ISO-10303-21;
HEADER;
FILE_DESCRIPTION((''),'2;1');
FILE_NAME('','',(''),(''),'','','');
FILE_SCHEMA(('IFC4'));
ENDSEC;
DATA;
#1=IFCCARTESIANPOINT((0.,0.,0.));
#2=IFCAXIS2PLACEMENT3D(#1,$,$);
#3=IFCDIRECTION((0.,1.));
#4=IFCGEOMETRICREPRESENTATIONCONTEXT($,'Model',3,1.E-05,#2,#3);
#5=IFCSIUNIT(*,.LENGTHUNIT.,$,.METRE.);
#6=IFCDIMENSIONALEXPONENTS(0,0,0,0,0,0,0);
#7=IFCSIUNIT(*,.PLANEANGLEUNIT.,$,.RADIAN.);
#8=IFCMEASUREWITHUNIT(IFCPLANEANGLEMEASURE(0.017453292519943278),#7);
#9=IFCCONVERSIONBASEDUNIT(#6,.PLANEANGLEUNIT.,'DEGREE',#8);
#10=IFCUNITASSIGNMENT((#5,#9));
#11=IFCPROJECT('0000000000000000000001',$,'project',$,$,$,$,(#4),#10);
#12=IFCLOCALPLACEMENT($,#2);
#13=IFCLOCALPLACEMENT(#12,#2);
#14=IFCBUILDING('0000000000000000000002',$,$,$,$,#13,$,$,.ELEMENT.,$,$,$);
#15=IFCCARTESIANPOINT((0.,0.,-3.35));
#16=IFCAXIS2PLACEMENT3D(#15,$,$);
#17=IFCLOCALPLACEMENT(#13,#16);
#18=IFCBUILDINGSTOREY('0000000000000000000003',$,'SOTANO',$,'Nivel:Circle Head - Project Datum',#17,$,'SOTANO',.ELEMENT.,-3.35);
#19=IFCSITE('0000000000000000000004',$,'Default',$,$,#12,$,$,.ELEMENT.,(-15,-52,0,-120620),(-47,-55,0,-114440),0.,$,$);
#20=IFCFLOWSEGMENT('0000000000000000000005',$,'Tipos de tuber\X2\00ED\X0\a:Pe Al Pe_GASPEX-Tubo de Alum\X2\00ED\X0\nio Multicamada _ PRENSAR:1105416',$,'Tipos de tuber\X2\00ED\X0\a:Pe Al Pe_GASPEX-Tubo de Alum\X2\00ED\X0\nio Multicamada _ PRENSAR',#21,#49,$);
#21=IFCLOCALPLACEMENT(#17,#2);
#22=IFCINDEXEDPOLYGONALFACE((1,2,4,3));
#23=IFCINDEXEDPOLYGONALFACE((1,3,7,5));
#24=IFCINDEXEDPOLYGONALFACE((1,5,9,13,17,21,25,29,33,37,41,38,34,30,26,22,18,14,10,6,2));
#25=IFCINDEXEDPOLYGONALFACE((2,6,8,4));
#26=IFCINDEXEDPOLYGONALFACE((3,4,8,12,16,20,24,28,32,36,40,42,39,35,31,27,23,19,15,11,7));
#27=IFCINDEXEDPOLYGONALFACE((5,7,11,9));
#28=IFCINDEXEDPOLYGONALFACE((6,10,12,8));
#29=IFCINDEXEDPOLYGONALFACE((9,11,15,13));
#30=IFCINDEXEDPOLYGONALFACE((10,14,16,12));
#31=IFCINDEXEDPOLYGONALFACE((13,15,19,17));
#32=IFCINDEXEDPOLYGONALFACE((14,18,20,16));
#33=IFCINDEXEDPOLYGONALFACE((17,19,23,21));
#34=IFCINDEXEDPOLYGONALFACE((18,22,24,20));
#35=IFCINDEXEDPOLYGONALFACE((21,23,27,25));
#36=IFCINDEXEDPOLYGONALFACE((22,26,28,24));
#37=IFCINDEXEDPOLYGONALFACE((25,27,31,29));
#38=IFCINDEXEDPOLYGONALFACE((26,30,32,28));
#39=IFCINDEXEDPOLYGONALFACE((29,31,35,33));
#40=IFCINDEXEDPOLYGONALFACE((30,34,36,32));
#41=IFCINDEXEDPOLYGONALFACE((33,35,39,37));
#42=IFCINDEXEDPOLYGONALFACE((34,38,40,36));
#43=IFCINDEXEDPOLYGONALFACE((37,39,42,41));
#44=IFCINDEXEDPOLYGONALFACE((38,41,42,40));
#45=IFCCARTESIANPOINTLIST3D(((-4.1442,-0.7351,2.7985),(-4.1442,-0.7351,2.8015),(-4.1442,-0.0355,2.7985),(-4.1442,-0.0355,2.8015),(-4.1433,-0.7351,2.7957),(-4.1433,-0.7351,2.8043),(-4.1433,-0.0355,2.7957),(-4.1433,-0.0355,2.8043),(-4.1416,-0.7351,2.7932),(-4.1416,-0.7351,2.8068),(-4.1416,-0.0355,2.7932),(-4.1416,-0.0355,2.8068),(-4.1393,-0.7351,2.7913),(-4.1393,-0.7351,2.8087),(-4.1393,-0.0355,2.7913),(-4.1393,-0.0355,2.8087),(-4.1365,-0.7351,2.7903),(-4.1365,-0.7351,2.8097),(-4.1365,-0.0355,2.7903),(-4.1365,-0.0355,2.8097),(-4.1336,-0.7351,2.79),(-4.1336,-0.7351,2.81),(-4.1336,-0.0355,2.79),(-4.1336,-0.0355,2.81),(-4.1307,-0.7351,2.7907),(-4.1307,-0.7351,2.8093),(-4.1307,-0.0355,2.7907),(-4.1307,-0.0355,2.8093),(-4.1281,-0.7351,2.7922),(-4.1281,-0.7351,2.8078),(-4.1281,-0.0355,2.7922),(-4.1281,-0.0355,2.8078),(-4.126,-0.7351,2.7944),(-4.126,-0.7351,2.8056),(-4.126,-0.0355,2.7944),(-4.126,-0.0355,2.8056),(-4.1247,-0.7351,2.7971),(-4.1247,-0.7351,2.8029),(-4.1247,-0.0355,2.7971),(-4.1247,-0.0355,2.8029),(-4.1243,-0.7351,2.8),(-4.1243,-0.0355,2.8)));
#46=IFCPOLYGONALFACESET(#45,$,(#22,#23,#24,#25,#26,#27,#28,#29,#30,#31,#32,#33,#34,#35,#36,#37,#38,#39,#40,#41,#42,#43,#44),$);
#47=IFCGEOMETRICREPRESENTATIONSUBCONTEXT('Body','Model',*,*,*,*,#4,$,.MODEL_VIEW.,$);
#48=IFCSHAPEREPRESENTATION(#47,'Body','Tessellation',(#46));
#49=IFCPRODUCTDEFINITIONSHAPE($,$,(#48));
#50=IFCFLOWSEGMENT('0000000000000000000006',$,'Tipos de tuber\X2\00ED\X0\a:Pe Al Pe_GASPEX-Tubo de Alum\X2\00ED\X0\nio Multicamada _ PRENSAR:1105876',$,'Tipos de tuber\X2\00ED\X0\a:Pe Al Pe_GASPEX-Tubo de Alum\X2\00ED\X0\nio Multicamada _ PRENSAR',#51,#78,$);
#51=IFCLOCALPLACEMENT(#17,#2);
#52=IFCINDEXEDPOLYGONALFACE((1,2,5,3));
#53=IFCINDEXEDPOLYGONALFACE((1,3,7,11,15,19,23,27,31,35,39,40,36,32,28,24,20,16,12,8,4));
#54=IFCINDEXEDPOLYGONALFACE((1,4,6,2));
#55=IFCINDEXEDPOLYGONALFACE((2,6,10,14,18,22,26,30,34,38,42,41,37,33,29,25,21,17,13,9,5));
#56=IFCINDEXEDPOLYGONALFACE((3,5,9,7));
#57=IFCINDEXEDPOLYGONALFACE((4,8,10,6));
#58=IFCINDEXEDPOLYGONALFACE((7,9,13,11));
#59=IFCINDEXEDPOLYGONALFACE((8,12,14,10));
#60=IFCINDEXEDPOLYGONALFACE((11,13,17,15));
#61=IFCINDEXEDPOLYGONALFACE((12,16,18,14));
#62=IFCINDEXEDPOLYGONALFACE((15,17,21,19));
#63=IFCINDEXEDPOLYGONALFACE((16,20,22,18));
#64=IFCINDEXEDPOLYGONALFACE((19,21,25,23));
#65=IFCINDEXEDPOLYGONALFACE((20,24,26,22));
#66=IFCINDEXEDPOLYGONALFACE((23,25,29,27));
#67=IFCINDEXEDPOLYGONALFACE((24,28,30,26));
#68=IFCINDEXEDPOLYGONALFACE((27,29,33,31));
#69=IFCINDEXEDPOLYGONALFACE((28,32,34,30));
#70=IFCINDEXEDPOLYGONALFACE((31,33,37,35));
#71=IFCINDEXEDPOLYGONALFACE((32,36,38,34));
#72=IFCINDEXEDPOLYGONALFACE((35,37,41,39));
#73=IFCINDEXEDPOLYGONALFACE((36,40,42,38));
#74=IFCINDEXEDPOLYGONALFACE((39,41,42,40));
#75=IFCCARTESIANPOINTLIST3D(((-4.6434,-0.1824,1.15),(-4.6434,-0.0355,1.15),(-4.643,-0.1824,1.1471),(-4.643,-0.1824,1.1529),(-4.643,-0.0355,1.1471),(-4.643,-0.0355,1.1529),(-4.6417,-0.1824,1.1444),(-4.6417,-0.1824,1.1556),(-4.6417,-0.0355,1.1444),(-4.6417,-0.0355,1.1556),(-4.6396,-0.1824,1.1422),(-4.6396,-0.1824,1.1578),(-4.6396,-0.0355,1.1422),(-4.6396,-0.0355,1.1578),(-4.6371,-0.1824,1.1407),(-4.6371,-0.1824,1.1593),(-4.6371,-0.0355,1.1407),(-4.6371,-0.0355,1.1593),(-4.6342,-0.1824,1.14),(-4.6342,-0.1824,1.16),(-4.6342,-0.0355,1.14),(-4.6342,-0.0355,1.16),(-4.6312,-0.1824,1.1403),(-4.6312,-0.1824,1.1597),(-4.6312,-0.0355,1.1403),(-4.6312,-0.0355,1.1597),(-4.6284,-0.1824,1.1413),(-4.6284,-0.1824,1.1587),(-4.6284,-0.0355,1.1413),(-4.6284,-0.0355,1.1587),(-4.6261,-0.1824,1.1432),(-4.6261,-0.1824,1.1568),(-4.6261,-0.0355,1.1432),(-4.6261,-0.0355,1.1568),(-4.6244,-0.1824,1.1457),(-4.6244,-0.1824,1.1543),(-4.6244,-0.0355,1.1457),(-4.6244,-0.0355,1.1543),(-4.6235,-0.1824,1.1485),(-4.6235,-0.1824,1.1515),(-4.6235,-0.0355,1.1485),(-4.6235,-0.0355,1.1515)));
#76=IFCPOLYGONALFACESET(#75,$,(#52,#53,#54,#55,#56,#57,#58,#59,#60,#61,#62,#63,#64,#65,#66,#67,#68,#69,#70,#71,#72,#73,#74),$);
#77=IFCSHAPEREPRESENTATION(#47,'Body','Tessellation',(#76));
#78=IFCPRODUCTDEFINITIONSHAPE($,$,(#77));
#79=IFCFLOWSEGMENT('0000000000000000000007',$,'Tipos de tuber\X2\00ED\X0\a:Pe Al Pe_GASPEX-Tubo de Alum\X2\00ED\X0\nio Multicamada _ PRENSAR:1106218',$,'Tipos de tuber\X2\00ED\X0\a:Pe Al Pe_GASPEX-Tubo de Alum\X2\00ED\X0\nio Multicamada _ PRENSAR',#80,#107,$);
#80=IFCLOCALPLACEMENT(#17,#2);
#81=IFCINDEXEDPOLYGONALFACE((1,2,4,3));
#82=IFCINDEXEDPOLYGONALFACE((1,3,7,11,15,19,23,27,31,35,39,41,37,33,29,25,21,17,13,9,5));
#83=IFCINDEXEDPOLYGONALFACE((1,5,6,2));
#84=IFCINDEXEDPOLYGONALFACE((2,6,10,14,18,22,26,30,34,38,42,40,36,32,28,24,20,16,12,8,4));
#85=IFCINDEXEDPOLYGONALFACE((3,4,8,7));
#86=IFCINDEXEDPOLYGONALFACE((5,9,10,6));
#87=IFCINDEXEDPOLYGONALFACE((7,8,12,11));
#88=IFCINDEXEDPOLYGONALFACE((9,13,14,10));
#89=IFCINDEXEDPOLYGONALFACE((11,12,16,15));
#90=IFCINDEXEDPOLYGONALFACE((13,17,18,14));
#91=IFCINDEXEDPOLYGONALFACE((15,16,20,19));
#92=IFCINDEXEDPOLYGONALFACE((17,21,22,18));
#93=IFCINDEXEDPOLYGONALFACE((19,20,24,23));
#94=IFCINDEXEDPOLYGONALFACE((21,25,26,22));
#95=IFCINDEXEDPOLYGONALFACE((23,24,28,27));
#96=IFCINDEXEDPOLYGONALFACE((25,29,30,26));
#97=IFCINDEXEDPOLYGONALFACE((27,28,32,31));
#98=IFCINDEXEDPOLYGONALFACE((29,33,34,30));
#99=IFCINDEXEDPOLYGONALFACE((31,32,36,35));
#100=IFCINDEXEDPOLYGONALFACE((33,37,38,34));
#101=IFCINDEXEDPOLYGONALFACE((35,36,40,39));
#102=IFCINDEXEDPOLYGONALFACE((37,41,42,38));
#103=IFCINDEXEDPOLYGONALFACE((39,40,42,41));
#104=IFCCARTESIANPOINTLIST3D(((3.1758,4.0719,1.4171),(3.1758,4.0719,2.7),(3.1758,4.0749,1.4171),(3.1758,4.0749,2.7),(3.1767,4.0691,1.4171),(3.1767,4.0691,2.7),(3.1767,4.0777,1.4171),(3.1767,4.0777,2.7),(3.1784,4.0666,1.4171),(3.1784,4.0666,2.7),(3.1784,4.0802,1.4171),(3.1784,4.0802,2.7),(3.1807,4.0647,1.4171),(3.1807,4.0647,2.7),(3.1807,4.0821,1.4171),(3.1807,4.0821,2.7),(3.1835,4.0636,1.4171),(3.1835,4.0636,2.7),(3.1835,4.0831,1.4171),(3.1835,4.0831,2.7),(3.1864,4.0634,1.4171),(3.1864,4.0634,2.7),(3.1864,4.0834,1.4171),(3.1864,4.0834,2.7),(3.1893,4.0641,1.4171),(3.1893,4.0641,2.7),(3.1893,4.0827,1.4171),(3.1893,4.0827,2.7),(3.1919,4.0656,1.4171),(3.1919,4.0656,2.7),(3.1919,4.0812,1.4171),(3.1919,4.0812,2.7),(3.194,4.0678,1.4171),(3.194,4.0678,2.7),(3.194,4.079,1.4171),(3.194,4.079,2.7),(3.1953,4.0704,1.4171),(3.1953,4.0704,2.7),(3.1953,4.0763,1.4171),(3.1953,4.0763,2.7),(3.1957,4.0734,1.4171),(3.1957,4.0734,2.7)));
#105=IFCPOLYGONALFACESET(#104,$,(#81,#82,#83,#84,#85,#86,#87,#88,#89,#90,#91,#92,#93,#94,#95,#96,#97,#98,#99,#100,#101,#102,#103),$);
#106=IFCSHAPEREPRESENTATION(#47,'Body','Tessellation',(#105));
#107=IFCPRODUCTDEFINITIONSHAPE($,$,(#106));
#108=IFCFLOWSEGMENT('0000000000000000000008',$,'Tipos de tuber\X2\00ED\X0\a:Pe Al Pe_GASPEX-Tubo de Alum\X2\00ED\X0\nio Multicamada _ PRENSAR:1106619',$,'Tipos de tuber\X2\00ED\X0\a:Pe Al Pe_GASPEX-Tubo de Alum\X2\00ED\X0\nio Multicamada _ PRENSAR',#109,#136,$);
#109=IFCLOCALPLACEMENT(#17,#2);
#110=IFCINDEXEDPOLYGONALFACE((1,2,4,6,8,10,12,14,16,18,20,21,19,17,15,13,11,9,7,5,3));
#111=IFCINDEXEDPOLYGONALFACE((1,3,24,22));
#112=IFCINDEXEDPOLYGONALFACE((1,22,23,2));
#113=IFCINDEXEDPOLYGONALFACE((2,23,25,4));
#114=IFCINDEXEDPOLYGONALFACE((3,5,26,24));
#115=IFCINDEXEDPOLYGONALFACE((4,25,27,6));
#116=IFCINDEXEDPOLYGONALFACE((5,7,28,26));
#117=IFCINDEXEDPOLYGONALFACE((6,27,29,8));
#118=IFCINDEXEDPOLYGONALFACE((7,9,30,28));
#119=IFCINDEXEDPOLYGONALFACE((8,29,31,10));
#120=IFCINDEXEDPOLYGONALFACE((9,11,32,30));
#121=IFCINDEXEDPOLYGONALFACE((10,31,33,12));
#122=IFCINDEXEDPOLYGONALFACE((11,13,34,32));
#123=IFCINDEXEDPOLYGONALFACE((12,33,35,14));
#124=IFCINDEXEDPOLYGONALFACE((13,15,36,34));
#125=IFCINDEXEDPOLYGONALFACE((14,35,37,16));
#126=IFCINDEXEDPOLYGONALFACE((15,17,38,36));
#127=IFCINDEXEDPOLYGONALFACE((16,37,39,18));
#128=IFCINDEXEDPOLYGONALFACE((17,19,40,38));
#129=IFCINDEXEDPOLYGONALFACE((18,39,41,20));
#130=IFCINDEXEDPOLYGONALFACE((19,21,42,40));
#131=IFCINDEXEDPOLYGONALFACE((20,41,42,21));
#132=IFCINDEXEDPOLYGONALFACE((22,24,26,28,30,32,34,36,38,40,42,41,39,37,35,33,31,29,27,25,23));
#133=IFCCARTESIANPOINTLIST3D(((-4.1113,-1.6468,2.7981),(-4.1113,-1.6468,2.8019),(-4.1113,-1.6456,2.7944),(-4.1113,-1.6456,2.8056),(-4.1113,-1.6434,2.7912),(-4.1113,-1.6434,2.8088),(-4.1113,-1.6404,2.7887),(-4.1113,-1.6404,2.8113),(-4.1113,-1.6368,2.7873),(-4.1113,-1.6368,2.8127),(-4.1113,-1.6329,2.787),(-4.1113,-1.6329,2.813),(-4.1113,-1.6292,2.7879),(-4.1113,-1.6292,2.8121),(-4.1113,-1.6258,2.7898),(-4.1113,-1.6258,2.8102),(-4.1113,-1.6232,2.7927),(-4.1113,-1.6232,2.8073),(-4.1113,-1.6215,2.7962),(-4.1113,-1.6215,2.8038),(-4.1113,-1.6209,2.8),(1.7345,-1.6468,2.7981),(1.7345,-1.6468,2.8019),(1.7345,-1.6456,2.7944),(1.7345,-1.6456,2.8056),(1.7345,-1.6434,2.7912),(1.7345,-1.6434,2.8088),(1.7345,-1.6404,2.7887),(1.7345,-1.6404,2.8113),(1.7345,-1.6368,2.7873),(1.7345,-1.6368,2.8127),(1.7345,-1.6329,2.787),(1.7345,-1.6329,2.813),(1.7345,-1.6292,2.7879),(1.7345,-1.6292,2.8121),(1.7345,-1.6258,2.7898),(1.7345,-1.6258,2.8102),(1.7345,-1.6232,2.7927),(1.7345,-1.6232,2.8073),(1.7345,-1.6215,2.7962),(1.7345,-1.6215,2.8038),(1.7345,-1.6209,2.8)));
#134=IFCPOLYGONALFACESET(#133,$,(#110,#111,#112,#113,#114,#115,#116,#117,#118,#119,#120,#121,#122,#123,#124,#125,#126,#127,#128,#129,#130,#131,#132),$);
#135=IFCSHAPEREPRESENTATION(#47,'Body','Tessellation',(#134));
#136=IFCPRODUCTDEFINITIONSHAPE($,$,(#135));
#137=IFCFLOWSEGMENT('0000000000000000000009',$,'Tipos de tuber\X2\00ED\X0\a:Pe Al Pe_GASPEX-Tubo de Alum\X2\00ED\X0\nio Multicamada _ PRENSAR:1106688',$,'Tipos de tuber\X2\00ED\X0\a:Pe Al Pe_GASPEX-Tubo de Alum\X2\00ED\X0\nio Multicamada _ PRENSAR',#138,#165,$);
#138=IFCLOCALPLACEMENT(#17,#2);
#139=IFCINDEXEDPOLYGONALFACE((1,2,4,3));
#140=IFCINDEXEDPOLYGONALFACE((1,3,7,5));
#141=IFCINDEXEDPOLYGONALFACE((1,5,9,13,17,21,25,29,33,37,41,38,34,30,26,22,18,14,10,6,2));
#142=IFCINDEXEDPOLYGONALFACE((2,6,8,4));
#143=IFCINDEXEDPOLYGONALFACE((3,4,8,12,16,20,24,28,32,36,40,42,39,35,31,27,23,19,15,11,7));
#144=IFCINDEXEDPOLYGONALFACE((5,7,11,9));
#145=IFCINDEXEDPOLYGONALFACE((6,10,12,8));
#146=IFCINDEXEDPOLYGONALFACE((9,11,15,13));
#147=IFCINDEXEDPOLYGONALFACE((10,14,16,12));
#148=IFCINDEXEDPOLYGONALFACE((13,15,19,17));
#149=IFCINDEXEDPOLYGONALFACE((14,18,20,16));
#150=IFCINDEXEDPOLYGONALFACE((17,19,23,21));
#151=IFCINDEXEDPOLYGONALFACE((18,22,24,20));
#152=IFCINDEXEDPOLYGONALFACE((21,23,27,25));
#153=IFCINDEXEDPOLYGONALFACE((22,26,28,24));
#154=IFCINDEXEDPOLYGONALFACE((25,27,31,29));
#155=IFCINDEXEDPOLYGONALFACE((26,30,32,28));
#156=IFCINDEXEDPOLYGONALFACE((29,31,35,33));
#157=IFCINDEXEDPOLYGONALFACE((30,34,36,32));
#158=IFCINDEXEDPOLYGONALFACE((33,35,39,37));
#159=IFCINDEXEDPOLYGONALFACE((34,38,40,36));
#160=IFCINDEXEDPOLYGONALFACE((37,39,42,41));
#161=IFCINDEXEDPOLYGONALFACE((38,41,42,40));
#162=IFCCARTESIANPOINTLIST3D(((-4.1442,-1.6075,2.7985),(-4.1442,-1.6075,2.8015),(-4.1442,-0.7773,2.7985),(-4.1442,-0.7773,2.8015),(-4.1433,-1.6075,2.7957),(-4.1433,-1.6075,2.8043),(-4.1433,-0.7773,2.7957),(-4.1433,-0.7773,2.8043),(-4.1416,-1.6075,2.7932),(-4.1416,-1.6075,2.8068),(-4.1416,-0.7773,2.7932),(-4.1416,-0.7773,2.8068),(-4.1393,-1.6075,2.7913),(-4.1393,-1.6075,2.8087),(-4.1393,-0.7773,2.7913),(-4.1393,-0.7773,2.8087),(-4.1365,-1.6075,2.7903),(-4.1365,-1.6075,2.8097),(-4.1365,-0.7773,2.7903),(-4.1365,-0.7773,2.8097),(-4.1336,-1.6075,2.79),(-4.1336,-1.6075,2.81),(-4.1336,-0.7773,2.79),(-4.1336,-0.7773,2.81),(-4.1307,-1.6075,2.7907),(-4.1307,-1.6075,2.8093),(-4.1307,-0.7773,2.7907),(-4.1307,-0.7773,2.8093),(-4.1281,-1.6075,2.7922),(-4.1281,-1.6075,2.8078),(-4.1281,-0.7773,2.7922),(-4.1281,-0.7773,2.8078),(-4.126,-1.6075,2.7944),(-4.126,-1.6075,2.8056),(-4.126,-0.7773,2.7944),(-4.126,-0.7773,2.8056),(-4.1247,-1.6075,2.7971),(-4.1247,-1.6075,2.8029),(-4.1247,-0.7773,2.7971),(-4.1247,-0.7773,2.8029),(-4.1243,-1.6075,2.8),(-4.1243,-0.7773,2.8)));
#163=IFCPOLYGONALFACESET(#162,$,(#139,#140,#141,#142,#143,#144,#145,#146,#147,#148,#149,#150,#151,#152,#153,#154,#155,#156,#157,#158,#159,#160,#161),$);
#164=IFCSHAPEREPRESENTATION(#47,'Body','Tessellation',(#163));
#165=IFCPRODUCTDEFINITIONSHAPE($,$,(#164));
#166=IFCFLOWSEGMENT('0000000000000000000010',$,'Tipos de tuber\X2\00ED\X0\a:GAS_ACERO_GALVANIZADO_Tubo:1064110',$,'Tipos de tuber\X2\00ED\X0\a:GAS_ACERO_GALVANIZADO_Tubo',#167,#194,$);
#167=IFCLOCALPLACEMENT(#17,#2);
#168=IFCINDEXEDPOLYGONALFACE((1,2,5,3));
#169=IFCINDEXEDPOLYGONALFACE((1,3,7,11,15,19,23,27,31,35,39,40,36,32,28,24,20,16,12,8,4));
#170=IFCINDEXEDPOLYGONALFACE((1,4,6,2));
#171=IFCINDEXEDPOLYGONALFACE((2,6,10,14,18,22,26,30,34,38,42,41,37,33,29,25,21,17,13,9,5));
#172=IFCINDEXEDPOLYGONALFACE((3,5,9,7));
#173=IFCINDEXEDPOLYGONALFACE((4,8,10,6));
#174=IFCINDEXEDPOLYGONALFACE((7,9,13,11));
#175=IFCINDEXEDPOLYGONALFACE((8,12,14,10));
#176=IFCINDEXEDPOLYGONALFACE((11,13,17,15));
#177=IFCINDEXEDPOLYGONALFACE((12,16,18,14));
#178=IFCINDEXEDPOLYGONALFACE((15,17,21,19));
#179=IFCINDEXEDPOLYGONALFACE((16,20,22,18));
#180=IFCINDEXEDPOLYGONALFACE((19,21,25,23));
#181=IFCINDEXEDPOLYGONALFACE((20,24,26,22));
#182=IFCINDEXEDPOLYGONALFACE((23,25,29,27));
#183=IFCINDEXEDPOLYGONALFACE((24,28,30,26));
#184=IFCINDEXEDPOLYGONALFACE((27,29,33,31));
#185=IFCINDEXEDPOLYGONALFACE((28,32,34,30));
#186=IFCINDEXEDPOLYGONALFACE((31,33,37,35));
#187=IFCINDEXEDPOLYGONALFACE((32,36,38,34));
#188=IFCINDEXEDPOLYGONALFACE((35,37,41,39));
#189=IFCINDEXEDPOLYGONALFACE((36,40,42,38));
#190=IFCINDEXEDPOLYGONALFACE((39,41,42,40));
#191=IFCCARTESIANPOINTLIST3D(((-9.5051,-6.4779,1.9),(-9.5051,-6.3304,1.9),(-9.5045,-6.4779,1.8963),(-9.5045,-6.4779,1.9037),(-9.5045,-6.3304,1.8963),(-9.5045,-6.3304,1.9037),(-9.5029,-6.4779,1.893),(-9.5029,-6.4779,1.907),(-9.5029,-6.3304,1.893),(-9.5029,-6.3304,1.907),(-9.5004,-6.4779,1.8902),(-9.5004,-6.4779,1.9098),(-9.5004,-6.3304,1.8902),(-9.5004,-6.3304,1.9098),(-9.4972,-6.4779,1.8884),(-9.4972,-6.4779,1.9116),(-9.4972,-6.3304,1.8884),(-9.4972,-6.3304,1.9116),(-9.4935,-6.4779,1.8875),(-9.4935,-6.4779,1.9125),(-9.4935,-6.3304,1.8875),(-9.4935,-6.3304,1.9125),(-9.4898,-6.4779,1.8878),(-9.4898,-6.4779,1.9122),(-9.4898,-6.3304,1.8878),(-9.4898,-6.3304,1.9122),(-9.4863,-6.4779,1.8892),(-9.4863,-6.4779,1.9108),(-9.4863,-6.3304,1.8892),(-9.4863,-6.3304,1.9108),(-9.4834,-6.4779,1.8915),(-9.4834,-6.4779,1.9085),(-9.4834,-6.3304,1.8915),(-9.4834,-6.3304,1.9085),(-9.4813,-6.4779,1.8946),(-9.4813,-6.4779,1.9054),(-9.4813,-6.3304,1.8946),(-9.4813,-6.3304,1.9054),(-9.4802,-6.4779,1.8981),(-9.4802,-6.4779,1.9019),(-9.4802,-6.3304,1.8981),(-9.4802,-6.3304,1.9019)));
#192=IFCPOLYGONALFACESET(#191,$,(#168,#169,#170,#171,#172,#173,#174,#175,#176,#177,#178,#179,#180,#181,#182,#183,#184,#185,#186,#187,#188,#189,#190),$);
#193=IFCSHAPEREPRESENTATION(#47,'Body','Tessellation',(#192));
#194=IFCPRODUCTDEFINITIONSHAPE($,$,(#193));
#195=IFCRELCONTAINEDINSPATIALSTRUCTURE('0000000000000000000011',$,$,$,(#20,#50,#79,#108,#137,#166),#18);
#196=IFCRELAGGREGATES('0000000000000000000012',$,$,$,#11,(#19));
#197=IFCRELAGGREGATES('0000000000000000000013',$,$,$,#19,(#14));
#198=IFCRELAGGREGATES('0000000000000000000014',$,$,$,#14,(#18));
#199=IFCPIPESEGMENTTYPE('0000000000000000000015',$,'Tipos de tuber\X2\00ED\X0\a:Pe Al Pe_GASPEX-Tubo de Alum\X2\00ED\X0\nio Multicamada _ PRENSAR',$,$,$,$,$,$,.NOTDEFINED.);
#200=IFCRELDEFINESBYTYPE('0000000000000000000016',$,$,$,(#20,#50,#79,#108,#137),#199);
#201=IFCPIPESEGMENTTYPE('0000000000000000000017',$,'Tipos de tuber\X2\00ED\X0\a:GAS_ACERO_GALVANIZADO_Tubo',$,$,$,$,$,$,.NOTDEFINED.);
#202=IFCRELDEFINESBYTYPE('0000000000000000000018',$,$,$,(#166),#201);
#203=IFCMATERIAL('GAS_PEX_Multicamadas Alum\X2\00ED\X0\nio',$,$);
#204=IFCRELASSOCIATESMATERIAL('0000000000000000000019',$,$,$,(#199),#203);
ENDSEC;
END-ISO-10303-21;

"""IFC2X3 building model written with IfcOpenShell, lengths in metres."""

from ifc_helpers import new_model, entity, si_unit, converted_unit, direction, frame, origin, origin_2d_with_axis, place, context, subcontext, project, spatial, circle, extrude, material, type_object, element, save


model = new_model("IFC2X3")

# Units and contexts
model_context = context("Model", 3, precision=1e-05, world=origin(), true_north=direction((0.0, 1.0)))
body_context = subcontext(model_context, "Body", "Model", "MODEL_VIEW")
ifc_project = project(units=[si_unit("LENGTHUNIT", "METRE"), converted_unit("PLANEANGLEUNIT", "DEGREE", entity("IfcPlaneAngleMeasure", 0.017453292519943278), si_unit("PLANEANGLEUNIT", "RADIAN"), dimensions=[0, 0, 0, 0, 0, 0, 0])], contexts=[model_context])

# Site, building, storey
site_placement = place(None, origin())
site = spatial("IfcSite", under=ifc_project, at=site_placement, Name="Default", CompositionType="ELEMENT", RefLatitude=(-15, -52, 0, -120620), RefLongitude=(-47, -55, 0, -114440), RefElevation=0.0)
building_placement = place(site_placement, origin())
building = spatial("IfcBuilding", under=site, at=building_placement, CompositionType="ELEMENT")
storey_placement = place(building_placement, frame((0.0, 0.0, -3.35)))
storey = spatial("IfcBuildingStorey", under=building, at=storey_placement, Name="SOTANO", ObjectType="Nivel:Circle Head - Project Datum", LongName="SOTANO", CompositionType="ELEMENT", Elevation=-3.35)

# Flow segments
ifc_material = material(Name="GAS_PEX_Multicamadas Alumínio")
pipe_segment_type_1 = type_object("IfcPipeSegmentType", Name="Tipos de tubería:Pe Al Pe_GASPEX-Tubo de Alumínio Multicamada _ PRENSAR", PredefinedType="NOTDEFINED", material=ifc_material)
flow_segment_1_placement = place(storey_placement, origin())
element("IfcFlowSegment", 1, at=flow_segment_1_placement, inside=storey, type_object=pipe_segment_type_1, Name="Tipos de tubería:Pe Al Pe_GASPEX-Tubo de Alumínio Multicamada _ PRENSAR:1105416", ObjectType="Tipos de tubería:Pe Al Pe_GASPEX-Tubo de Alumínio Multicamada _ PRENSAR", context=body_context, shape_type="SweptSolid", body=[
    extrude(circle(Radius=0.01, at=origin_2d_with_axis()), frame((-4.1343, -0.7351, 2.8), z_axis=(0.0, 1.0, 0.0), x_axis=(1.0, 0.0, 0.0)), (0.0, 0.0, 1.0), 0.6995),
])
flow_segment_2_placement = place(storey_placement, origin())
element("IfcFlowSegment", 2, at=flow_segment_2_placement, inside=storey, type_object=pipe_segment_type_1, Name="Tipos de tubería:Pe Al Pe_GASPEX-Tubo de Alumínio Multicamada _ PRENSAR:1105876", ObjectType="Tipos de tubería:Pe Al Pe_GASPEX-Tubo de Alumínio Multicamada _ PRENSAR", context=body_context, shape_type="SweptSolid", body=[
    extrude(circle(Radius=0.01, at=origin_2d_with_axis()), frame((-4.6334, -0.1824, 1.15), z_axis=(0.0, 1.0, 0.0), x_axis=(-1.0, 0.0, 0.0)), (0.0, 0.0, 1.0), 0.1469),
])
flow_segment_3_placement = place(storey_placement, origin())
element("IfcFlowSegment", 3, at=flow_segment_3_placement, inside=storey, type_object=pipe_segment_type_1, Name="Tipos de tubería:Pe Al Pe_GASPEX-Tubo de Alumínio Multicamada _ PRENSAR:1106218", ObjectType="Tipos de tubería:Pe Al Pe_GASPEX-Tubo de Alumínio Multicamada _ PRENSAR", context=body_context, shape_type="SweptSolid", body=[
    extrude(circle(Radius=0.01, at=origin_2d_with_axis()), frame((3.1857, 4.0734, 1.4171)), (0.0, 0.0, 1.0), 1.2828),
])
flow_segment_4_placement = place(storey_placement, origin())
element("IfcFlowSegment", 4, at=flow_segment_4_placement, inside=storey, type_object=pipe_segment_type_1, Name="Tipos de tubería:Pe Al Pe_GASPEX-Tubo de Alumínio Multicamada _ PRENSAR:1106619", ObjectType="Tipos de tubería:Pe Al Pe_GASPEX-Tubo de Alumínio Multicamada _ PRENSAR", context=body_context, shape_type="SweptSolid", body=[
    extrude(circle(Radius=0.013, at=origin_2d_with_axis()), frame((-4.1113, -1.6339, 2.8), z_axis=(1.0, 0.0, 0.0), x_axis=(0.0, 1.0, 0.0)), (0.0, 0.0, 1.0), 5.8458),
])
flow_segment_5_placement = place(storey_placement, origin())
element("IfcFlowSegment", 5, at=flow_segment_5_placement, inside=storey, type_object=pipe_segment_type_1, Name="Tipos de tubería:Pe Al Pe_GASPEX-Tubo de Alumínio Multicamada _ PRENSAR:1106688", ObjectType="Tipos de tubería:Pe Al Pe_GASPEX-Tubo de Alumínio Multicamada _ PRENSAR", context=body_context, shape_type="SweptSolid", body=[
    extrude(circle(Radius=0.01, at=origin_2d_with_axis()), frame((-4.1343, -1.6075, 2.8), z_axis=(0.0, 1.0, 0.0), x_axis=(1.0, 0.0, 0.0)), (0.0, 0.0, 1.0), 0.8302),
])
pipe_segment_type_2 = type_object("IfcPipeSegmentType", Name="Tipos de tubería:GAS_ACERO_GALVANIZADO_Tubo", PredefinedType="NOTDEFINED")
flow_segment_6_placement = place(storey_placement, origin())
element("IfcFlowSegment", 6, at=flow_segment_6_placement, inside=storey, type_object=pipe_segment_type_2, Name="Tipos de tubería:GAS_ACERO_GALVANIZADO_Tubo:1064110", ObjectType="Tipos de tubería:GAS_ACERO_GALVANIZADO_Tubo", context=body_context, shape_type="SweptSolid", body=[
    extrude(circle(Radius=0.0125, at=origin_2d_with_axis()), frame((-9.4926, -6.4779, 1.9), z_axis=(0.000008, 1.0, 0.0), x_axis=(-1.0, 0.000008, 0.0)), (0.0, 0.0, 1.0), 0.1475),
])

save(model, "model.ifc")
